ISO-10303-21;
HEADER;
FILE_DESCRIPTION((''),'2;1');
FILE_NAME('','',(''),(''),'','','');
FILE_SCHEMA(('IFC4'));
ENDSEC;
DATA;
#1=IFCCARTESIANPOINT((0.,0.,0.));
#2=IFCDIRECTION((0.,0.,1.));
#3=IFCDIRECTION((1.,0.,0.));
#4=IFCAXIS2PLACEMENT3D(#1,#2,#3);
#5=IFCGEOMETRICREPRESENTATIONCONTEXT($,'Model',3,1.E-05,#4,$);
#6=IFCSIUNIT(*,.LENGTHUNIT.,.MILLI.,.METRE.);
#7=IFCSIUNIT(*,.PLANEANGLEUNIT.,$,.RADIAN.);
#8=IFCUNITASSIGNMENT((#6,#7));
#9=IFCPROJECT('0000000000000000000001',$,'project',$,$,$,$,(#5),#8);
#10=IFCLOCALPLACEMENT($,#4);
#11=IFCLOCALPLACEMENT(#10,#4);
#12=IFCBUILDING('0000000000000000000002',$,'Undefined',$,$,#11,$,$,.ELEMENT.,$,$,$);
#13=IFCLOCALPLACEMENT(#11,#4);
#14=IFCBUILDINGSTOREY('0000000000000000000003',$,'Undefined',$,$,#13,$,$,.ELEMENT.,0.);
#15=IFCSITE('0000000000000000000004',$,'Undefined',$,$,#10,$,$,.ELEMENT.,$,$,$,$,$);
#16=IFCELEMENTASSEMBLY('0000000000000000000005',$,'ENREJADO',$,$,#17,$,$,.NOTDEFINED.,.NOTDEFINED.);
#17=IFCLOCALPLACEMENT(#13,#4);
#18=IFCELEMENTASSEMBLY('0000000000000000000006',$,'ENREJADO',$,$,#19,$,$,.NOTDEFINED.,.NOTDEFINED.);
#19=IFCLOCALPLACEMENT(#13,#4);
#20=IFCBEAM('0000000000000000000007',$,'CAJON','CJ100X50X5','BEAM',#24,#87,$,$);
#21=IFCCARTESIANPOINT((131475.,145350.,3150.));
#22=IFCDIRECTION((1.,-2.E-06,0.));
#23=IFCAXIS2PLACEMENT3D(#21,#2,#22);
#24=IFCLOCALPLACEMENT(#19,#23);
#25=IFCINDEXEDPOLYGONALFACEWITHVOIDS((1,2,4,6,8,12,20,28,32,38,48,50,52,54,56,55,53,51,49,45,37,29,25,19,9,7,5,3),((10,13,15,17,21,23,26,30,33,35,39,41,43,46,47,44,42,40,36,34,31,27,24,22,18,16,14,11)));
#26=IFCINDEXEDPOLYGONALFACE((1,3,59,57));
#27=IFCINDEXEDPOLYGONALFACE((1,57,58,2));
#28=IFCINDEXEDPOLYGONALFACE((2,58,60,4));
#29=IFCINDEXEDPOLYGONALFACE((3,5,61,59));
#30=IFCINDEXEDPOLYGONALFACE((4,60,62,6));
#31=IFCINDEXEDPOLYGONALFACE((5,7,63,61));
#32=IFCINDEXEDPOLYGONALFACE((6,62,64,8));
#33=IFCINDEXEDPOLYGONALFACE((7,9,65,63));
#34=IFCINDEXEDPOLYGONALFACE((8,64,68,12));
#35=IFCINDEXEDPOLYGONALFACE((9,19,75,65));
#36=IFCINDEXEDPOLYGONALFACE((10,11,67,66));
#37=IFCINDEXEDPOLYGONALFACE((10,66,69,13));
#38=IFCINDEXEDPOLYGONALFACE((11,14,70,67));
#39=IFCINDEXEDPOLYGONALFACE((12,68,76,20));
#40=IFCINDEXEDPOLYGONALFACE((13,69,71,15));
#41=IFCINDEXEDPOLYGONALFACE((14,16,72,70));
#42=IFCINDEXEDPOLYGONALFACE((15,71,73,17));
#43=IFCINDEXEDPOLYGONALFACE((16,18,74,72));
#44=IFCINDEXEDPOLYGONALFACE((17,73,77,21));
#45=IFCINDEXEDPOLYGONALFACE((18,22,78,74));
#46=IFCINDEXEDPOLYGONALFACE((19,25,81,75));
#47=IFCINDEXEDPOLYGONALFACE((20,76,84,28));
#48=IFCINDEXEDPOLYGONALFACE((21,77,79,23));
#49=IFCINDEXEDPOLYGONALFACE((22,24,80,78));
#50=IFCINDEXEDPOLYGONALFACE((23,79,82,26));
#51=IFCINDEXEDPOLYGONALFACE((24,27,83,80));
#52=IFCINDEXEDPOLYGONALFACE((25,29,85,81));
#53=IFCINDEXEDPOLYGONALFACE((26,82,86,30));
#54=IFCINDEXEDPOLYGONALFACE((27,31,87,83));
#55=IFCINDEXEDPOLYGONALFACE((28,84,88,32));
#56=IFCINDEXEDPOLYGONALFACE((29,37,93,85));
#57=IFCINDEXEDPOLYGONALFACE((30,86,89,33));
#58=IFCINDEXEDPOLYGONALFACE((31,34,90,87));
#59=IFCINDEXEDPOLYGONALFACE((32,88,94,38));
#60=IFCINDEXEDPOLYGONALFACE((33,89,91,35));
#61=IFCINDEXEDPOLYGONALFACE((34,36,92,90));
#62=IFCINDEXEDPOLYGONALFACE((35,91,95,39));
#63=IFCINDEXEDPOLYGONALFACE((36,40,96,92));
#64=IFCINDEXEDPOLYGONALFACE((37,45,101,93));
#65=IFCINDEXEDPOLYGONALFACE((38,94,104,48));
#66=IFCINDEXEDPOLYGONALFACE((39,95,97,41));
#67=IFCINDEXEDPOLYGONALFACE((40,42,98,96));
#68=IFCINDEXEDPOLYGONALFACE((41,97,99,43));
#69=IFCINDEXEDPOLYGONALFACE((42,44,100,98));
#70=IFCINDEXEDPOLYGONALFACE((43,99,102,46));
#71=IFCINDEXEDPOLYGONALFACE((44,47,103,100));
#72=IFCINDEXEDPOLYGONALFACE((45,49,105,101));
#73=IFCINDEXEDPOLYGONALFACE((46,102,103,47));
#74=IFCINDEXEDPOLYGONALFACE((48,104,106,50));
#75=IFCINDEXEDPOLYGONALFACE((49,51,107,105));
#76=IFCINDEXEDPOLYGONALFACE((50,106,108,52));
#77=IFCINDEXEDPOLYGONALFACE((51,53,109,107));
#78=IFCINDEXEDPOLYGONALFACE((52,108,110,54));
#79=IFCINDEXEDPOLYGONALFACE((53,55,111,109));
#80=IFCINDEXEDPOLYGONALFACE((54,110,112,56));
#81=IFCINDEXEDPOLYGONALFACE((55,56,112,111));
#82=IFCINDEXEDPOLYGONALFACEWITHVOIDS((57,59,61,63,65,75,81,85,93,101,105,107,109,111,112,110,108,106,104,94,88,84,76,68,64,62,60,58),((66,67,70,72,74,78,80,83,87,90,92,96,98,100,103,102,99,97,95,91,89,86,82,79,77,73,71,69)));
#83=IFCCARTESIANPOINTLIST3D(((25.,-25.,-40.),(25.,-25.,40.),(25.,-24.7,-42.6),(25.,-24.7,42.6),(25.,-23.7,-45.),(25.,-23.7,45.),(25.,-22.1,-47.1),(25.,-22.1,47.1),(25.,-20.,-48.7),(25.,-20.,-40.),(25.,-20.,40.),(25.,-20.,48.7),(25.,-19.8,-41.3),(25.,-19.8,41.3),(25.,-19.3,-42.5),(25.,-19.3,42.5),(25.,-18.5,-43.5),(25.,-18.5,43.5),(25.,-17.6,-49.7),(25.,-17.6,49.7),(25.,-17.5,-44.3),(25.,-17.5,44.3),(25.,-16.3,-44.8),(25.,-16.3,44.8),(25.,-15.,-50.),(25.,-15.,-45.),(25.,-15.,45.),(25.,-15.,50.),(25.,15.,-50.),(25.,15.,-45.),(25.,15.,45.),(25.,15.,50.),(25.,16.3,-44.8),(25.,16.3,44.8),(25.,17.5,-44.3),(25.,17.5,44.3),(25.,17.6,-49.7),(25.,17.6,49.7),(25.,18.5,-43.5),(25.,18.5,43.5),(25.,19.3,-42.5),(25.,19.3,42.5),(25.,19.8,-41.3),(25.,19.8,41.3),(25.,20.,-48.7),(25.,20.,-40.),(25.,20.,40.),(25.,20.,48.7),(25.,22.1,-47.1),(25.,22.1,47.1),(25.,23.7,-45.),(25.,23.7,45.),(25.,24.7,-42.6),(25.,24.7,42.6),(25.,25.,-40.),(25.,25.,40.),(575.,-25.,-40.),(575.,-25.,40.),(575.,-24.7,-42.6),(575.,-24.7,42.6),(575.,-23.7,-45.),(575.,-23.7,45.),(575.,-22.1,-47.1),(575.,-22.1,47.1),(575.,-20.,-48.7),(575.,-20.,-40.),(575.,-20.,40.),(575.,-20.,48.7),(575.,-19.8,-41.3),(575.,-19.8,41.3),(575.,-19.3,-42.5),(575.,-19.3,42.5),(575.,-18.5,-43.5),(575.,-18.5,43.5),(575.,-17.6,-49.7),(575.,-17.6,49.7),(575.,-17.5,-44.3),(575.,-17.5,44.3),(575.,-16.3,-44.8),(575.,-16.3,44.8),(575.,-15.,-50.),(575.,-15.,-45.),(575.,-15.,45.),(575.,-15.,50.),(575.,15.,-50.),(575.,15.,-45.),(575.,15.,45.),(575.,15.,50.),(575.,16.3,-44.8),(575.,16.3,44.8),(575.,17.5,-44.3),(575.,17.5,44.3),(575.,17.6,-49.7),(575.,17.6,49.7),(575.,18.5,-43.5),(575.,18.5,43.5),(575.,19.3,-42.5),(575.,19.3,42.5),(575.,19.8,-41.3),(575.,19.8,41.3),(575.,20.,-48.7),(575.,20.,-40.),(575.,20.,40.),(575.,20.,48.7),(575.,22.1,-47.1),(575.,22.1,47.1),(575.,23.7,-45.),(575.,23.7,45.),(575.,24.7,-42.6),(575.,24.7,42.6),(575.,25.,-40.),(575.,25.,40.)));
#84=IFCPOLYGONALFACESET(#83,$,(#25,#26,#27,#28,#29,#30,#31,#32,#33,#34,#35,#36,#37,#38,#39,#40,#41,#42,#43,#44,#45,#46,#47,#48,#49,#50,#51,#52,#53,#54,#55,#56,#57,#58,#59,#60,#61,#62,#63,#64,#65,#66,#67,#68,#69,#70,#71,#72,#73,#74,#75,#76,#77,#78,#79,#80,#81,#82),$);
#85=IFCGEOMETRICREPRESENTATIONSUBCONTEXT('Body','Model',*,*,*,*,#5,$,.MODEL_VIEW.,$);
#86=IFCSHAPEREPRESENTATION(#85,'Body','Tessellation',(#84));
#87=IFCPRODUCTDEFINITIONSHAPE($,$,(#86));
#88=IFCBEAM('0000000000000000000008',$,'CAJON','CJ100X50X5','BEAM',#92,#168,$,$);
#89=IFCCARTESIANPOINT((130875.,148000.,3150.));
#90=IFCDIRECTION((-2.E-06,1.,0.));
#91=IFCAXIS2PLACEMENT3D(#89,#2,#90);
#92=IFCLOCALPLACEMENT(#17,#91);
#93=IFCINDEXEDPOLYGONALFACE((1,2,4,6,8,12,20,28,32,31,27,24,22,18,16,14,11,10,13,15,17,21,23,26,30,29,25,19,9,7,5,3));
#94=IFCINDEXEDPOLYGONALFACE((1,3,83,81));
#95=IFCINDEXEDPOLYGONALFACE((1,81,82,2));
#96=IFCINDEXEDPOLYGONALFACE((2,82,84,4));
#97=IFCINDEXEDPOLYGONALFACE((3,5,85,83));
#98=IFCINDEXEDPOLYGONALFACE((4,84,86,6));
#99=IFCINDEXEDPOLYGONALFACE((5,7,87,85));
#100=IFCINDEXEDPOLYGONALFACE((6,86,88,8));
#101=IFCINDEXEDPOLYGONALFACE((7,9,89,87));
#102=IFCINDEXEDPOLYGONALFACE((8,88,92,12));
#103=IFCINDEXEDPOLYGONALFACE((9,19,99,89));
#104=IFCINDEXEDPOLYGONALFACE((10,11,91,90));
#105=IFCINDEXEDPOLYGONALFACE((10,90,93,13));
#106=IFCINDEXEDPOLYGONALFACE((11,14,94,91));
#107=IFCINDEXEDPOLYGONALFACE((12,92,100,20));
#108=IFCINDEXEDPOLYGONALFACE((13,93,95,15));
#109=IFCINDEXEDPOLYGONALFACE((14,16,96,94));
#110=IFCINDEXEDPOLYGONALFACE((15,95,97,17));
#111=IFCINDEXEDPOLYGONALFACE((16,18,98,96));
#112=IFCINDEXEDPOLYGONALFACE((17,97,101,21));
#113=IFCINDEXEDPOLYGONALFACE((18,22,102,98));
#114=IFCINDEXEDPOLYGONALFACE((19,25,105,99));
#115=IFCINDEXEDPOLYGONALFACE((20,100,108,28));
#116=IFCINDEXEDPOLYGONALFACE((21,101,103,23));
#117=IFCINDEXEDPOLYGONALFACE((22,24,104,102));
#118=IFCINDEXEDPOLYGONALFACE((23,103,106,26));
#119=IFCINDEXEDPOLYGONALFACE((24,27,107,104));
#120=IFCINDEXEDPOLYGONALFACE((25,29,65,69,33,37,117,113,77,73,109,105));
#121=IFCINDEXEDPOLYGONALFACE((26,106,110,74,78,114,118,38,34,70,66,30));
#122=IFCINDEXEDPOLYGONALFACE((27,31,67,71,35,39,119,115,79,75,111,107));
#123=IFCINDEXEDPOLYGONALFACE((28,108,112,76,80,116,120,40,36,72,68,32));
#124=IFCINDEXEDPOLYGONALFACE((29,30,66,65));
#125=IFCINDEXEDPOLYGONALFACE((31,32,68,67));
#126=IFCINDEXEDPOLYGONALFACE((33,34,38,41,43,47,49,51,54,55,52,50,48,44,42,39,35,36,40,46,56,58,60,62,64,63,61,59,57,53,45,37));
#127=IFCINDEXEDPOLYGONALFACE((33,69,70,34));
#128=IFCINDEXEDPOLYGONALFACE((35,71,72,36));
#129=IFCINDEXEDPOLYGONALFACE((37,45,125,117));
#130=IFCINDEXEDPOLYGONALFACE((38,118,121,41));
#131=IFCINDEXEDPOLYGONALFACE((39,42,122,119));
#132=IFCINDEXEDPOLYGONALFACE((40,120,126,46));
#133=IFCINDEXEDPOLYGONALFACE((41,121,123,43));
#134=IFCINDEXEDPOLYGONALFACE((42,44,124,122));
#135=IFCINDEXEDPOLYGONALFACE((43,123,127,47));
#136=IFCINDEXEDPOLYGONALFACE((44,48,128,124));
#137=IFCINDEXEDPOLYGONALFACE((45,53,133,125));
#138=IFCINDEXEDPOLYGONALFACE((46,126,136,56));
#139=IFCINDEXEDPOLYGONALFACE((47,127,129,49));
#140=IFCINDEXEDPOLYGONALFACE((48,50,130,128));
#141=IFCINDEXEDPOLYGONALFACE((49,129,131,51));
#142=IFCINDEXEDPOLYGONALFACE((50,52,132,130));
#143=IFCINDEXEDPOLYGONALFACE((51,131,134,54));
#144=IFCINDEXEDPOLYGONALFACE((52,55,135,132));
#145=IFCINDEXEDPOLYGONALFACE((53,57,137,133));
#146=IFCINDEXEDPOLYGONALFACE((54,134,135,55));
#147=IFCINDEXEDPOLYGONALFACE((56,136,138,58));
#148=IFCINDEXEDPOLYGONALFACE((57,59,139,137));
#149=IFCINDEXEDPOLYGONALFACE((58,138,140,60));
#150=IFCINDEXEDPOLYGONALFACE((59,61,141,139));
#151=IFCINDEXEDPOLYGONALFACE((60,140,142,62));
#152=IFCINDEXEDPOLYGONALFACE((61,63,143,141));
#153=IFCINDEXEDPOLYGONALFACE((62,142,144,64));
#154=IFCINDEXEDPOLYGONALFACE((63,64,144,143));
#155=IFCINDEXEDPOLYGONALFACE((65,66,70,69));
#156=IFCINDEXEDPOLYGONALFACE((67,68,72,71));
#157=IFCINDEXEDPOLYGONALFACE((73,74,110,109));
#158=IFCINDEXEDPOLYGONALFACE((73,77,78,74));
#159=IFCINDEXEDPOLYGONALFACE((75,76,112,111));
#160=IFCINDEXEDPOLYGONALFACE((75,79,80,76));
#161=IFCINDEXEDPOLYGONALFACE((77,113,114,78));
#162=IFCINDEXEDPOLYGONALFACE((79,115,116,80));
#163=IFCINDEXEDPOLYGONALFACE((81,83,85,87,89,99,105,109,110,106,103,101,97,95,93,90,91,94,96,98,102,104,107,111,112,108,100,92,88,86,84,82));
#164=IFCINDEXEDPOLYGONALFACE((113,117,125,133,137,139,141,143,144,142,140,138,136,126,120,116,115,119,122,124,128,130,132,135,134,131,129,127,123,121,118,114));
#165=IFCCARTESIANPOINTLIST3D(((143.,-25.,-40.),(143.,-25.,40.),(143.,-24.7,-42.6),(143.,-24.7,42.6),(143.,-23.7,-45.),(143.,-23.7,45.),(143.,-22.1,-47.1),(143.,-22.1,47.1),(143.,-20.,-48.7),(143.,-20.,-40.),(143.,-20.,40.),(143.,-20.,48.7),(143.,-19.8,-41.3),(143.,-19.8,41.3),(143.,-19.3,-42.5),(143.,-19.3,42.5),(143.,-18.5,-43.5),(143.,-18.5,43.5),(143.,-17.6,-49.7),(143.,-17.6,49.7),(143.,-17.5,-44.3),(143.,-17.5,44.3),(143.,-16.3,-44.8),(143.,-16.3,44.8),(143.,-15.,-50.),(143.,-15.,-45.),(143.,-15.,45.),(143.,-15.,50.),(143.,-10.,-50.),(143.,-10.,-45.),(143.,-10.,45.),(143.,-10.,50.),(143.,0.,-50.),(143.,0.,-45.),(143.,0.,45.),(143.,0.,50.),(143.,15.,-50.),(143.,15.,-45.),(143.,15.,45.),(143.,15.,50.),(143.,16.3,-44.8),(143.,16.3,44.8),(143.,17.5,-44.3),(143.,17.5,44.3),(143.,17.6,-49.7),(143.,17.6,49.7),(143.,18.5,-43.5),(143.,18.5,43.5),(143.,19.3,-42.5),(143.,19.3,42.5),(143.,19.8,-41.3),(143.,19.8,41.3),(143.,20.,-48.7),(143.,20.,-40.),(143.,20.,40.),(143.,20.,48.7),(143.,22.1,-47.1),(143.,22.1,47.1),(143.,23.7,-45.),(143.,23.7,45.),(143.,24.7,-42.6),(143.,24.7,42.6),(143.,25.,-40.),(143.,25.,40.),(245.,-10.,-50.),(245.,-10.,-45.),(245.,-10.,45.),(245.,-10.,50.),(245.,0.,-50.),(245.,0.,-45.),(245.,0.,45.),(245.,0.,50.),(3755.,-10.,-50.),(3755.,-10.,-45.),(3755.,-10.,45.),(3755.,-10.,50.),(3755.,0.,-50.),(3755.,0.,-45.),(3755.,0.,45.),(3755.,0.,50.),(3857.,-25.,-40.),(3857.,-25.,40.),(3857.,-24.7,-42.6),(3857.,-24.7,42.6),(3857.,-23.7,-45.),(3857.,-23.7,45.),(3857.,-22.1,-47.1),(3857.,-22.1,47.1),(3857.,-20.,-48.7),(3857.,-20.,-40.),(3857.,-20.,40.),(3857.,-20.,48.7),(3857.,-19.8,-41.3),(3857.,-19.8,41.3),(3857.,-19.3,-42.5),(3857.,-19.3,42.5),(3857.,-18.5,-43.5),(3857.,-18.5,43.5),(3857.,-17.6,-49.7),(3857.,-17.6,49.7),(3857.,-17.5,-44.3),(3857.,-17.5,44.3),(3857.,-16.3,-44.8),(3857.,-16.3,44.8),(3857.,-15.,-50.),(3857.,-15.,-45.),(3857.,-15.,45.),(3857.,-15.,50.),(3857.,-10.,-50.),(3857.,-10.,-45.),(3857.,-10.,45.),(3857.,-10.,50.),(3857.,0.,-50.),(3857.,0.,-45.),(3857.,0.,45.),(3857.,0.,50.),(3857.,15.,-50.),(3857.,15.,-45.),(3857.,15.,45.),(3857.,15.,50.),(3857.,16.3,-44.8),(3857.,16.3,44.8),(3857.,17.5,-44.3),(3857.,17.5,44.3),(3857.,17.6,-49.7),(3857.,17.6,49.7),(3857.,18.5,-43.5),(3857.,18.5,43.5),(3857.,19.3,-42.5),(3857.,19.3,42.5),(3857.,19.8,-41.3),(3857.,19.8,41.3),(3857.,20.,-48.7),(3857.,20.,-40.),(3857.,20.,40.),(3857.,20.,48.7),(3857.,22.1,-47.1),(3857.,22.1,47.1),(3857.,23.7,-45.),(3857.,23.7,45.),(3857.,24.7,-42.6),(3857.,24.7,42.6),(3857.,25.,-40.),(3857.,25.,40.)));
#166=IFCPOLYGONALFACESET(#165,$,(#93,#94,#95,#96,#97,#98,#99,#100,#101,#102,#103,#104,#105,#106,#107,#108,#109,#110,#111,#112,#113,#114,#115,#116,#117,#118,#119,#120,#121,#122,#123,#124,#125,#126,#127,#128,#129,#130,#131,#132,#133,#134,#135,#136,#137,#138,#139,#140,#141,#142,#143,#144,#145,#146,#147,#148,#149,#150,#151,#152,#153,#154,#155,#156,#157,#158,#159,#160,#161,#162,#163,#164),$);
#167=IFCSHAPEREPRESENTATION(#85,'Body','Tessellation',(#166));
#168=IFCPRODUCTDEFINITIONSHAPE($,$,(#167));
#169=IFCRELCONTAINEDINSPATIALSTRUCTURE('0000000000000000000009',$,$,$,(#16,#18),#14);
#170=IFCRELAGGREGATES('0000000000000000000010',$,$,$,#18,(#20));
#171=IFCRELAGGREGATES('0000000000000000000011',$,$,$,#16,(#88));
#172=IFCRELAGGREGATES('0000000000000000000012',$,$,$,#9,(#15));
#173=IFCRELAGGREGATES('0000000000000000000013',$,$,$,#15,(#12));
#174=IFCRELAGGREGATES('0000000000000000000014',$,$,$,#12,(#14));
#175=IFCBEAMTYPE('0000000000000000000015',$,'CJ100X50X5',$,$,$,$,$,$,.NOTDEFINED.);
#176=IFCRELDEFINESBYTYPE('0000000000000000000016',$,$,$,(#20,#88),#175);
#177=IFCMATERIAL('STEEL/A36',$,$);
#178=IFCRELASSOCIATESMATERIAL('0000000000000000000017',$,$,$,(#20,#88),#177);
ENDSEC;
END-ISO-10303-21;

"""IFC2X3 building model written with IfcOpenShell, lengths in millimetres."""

from ifc_helpers import new_model, si_unit, frame, origin_with_axes, origin_2d_with_axis, place, context, subcontext, project, spatial, rectangle, hollow_rectangle, extrude, boolean, clip, halfspace, material, type_object, element, aggregate, save


model = new_model("IFC2X3")

# Units and contexts
model_context = context("Model", 3, precision=1e-05, world=origin_with_axes())
body_context = subcontext(model_context, "Body", "Model", "MODEL_VIEW")
ifc_project = project(units=[si_unit("LENGTHUNIT", "METRE", prefix="MILLI"), si_unit("PLANEANGLEUNIT", "RADIAN")], contexts=[model_context])

# Site, building, storey
site_placement = place(None, origin_with_axes())
site = spatial("IfcSite", under=ifc_project, at=site_placement, Name="Undefined", CompositionType="ELEMENT")
building_placement = place(site_placement, origin_with_axes())
building = spatial("IfcBuilding", under=site, at=building_placement, Name="Undefined", CompositionType="ELEMENT")
storey_placement = place(building_placement, origin_with_axes())
storey = spatial("IfcBuildingStorey", under=building, at=storey_placement, Name="Undefined", CompositionType="ELEMENT", Elevation=0.0)

# Shared definitions
ifc_material_1 = material(Name="STEEL/A36")

# Element assembly
assembly_1_placement = place(storey_placement, origin_with_axes())
assembly_1 = element("IfcElementAssembly", 1, at=assembly_1_placement, inside=storey, Name="ENREJADO", AssemblyPlace="NOTDEFINED", PredefinedType="NOTDEFINED")
beam_type_1 = type_object("IfcBeamType", Name="CJ100X50X5", PredefinedType="NOTDEFINED")

# Element assembly, beam
assembly_2_placement = place(storey_placement, origin_with_axes())
assembly_2 = element("IfcElementAssembly", 2, at=assembly_2_placement, inside=storey, Name="ENREJADO", AssemblyPlace="NOTDEFINED", PredefinedType="NOTDEFINED")
beam_1_placement = place(assembly_2_placement, frame((131475.0, 145350.0, 3150.0), z_axis=(0.0, 0.0, 1.0), x_axis=(1.0, -0.000002, 0.0)))
beam_1 = element("IfcBeam", 3, at=beam_1_placement, type_object=beam_type_1, material=ifc_material_1, Name="CAJON", Description="CJ100X50X5", ObjectType="BEAM", context=body_context, shape_type="Clipping", body=[
    clip(clip(extrude(hollow_rectangle(XDim=50.0, YDim=100.0, WallThickness=5.0, InnerFilletRadius=5.0, OuterFilletRadius=10.0, at=origin_2d_with_axis()), frame((600.0, 0.0, 0.0), z_axis=(-1.0, 0.0, 0.0), x_axis=(0.0, -1.0, 0.0)), (0.0, 0.0, 1.0), 600.0), halfspace(frame((575.0, -25.0, 1050.0), z_axis=(1.0, 0.000003, 0.0), x_axis=(-0.000002, 1.0, 0.0)), False)), halfspace(frame((25.0, 25.0, 1050.0), z_axis=(-1.0, -0.000002, 0.0), x_axis=(0.000003, -1.0, 0.0)), False)),
])

# Beam
beam_2_placement = place(assembly_1_placement, frame((130875.0, 148000.0, 3150.0), z_axis=(0.0, 0.0, 1.0), x_axis=(-0.000002, 1.0, 0.0)))
beam_2 = element("IfcBeam", 4, at=beam_2_placement, type_object=beam_type_1, material=ifc_material_1, Name="CAJON", Description="CJ100X50X5", ObjectType="BEAM", context=body_context, shape_type="CSG", body=[
    boolean("DIFFERENCE", boolean("DIFFERENCE", boolean("DIFFERENCE", boolean("DIFFERENCE", extrude(hollow_rectangle(XDim=50.0, YDim=100.0, WallThickness=5.0, InnerFilletRadius=5.0, OuterFilletRadius=10.0, at=origin_2d_with_axis()), frame((4000.0, 0.0, 0.0), z_axis=(-1.0, 0.0, 0.0), x_axis=(0.0, -1.0, 0.0)), (0.0, 0.0, 1.0), 4000.0), extrude(rectangle(XDim=10.0, YDim=104.0, at=origin_2d_with_axis()), frame((3755.0, -5.0, 0.0), z_axis=(1.0, 0.0, 0.0), x_axis=(0.0, 1.0, 0.0)), (0.0, 0.0, 1.0), 120.0)), extrude(rectangle(XDim=10.0, YDim=104.0, at=origin_2d_with_axis()), frame((245.0, -5.0, 0.0), z_axis=(-1.0, 0.000003, 0.0), x_axis=(0.000002, 1.0, 0.0)), (0.0, 0.0, 1.0), 120.0)), halfspace(frame((3857.0, 200.0, 50.0), z_axis=(-1.0, 0.0, 0.0), x_axis=(0.0, -1.0, 0.0)), True)), halfspace(frame((143.0, 200.0, -50.0), z_axis=(1.0, -0.000003, 0.0), x_axis=(-0.000002, -1.0, 0.0)), True)),
])

aggregate(assembly_2, [beam_1])
aggregate(assembly_1, [beam_2])

save(model, "model.ifc")
